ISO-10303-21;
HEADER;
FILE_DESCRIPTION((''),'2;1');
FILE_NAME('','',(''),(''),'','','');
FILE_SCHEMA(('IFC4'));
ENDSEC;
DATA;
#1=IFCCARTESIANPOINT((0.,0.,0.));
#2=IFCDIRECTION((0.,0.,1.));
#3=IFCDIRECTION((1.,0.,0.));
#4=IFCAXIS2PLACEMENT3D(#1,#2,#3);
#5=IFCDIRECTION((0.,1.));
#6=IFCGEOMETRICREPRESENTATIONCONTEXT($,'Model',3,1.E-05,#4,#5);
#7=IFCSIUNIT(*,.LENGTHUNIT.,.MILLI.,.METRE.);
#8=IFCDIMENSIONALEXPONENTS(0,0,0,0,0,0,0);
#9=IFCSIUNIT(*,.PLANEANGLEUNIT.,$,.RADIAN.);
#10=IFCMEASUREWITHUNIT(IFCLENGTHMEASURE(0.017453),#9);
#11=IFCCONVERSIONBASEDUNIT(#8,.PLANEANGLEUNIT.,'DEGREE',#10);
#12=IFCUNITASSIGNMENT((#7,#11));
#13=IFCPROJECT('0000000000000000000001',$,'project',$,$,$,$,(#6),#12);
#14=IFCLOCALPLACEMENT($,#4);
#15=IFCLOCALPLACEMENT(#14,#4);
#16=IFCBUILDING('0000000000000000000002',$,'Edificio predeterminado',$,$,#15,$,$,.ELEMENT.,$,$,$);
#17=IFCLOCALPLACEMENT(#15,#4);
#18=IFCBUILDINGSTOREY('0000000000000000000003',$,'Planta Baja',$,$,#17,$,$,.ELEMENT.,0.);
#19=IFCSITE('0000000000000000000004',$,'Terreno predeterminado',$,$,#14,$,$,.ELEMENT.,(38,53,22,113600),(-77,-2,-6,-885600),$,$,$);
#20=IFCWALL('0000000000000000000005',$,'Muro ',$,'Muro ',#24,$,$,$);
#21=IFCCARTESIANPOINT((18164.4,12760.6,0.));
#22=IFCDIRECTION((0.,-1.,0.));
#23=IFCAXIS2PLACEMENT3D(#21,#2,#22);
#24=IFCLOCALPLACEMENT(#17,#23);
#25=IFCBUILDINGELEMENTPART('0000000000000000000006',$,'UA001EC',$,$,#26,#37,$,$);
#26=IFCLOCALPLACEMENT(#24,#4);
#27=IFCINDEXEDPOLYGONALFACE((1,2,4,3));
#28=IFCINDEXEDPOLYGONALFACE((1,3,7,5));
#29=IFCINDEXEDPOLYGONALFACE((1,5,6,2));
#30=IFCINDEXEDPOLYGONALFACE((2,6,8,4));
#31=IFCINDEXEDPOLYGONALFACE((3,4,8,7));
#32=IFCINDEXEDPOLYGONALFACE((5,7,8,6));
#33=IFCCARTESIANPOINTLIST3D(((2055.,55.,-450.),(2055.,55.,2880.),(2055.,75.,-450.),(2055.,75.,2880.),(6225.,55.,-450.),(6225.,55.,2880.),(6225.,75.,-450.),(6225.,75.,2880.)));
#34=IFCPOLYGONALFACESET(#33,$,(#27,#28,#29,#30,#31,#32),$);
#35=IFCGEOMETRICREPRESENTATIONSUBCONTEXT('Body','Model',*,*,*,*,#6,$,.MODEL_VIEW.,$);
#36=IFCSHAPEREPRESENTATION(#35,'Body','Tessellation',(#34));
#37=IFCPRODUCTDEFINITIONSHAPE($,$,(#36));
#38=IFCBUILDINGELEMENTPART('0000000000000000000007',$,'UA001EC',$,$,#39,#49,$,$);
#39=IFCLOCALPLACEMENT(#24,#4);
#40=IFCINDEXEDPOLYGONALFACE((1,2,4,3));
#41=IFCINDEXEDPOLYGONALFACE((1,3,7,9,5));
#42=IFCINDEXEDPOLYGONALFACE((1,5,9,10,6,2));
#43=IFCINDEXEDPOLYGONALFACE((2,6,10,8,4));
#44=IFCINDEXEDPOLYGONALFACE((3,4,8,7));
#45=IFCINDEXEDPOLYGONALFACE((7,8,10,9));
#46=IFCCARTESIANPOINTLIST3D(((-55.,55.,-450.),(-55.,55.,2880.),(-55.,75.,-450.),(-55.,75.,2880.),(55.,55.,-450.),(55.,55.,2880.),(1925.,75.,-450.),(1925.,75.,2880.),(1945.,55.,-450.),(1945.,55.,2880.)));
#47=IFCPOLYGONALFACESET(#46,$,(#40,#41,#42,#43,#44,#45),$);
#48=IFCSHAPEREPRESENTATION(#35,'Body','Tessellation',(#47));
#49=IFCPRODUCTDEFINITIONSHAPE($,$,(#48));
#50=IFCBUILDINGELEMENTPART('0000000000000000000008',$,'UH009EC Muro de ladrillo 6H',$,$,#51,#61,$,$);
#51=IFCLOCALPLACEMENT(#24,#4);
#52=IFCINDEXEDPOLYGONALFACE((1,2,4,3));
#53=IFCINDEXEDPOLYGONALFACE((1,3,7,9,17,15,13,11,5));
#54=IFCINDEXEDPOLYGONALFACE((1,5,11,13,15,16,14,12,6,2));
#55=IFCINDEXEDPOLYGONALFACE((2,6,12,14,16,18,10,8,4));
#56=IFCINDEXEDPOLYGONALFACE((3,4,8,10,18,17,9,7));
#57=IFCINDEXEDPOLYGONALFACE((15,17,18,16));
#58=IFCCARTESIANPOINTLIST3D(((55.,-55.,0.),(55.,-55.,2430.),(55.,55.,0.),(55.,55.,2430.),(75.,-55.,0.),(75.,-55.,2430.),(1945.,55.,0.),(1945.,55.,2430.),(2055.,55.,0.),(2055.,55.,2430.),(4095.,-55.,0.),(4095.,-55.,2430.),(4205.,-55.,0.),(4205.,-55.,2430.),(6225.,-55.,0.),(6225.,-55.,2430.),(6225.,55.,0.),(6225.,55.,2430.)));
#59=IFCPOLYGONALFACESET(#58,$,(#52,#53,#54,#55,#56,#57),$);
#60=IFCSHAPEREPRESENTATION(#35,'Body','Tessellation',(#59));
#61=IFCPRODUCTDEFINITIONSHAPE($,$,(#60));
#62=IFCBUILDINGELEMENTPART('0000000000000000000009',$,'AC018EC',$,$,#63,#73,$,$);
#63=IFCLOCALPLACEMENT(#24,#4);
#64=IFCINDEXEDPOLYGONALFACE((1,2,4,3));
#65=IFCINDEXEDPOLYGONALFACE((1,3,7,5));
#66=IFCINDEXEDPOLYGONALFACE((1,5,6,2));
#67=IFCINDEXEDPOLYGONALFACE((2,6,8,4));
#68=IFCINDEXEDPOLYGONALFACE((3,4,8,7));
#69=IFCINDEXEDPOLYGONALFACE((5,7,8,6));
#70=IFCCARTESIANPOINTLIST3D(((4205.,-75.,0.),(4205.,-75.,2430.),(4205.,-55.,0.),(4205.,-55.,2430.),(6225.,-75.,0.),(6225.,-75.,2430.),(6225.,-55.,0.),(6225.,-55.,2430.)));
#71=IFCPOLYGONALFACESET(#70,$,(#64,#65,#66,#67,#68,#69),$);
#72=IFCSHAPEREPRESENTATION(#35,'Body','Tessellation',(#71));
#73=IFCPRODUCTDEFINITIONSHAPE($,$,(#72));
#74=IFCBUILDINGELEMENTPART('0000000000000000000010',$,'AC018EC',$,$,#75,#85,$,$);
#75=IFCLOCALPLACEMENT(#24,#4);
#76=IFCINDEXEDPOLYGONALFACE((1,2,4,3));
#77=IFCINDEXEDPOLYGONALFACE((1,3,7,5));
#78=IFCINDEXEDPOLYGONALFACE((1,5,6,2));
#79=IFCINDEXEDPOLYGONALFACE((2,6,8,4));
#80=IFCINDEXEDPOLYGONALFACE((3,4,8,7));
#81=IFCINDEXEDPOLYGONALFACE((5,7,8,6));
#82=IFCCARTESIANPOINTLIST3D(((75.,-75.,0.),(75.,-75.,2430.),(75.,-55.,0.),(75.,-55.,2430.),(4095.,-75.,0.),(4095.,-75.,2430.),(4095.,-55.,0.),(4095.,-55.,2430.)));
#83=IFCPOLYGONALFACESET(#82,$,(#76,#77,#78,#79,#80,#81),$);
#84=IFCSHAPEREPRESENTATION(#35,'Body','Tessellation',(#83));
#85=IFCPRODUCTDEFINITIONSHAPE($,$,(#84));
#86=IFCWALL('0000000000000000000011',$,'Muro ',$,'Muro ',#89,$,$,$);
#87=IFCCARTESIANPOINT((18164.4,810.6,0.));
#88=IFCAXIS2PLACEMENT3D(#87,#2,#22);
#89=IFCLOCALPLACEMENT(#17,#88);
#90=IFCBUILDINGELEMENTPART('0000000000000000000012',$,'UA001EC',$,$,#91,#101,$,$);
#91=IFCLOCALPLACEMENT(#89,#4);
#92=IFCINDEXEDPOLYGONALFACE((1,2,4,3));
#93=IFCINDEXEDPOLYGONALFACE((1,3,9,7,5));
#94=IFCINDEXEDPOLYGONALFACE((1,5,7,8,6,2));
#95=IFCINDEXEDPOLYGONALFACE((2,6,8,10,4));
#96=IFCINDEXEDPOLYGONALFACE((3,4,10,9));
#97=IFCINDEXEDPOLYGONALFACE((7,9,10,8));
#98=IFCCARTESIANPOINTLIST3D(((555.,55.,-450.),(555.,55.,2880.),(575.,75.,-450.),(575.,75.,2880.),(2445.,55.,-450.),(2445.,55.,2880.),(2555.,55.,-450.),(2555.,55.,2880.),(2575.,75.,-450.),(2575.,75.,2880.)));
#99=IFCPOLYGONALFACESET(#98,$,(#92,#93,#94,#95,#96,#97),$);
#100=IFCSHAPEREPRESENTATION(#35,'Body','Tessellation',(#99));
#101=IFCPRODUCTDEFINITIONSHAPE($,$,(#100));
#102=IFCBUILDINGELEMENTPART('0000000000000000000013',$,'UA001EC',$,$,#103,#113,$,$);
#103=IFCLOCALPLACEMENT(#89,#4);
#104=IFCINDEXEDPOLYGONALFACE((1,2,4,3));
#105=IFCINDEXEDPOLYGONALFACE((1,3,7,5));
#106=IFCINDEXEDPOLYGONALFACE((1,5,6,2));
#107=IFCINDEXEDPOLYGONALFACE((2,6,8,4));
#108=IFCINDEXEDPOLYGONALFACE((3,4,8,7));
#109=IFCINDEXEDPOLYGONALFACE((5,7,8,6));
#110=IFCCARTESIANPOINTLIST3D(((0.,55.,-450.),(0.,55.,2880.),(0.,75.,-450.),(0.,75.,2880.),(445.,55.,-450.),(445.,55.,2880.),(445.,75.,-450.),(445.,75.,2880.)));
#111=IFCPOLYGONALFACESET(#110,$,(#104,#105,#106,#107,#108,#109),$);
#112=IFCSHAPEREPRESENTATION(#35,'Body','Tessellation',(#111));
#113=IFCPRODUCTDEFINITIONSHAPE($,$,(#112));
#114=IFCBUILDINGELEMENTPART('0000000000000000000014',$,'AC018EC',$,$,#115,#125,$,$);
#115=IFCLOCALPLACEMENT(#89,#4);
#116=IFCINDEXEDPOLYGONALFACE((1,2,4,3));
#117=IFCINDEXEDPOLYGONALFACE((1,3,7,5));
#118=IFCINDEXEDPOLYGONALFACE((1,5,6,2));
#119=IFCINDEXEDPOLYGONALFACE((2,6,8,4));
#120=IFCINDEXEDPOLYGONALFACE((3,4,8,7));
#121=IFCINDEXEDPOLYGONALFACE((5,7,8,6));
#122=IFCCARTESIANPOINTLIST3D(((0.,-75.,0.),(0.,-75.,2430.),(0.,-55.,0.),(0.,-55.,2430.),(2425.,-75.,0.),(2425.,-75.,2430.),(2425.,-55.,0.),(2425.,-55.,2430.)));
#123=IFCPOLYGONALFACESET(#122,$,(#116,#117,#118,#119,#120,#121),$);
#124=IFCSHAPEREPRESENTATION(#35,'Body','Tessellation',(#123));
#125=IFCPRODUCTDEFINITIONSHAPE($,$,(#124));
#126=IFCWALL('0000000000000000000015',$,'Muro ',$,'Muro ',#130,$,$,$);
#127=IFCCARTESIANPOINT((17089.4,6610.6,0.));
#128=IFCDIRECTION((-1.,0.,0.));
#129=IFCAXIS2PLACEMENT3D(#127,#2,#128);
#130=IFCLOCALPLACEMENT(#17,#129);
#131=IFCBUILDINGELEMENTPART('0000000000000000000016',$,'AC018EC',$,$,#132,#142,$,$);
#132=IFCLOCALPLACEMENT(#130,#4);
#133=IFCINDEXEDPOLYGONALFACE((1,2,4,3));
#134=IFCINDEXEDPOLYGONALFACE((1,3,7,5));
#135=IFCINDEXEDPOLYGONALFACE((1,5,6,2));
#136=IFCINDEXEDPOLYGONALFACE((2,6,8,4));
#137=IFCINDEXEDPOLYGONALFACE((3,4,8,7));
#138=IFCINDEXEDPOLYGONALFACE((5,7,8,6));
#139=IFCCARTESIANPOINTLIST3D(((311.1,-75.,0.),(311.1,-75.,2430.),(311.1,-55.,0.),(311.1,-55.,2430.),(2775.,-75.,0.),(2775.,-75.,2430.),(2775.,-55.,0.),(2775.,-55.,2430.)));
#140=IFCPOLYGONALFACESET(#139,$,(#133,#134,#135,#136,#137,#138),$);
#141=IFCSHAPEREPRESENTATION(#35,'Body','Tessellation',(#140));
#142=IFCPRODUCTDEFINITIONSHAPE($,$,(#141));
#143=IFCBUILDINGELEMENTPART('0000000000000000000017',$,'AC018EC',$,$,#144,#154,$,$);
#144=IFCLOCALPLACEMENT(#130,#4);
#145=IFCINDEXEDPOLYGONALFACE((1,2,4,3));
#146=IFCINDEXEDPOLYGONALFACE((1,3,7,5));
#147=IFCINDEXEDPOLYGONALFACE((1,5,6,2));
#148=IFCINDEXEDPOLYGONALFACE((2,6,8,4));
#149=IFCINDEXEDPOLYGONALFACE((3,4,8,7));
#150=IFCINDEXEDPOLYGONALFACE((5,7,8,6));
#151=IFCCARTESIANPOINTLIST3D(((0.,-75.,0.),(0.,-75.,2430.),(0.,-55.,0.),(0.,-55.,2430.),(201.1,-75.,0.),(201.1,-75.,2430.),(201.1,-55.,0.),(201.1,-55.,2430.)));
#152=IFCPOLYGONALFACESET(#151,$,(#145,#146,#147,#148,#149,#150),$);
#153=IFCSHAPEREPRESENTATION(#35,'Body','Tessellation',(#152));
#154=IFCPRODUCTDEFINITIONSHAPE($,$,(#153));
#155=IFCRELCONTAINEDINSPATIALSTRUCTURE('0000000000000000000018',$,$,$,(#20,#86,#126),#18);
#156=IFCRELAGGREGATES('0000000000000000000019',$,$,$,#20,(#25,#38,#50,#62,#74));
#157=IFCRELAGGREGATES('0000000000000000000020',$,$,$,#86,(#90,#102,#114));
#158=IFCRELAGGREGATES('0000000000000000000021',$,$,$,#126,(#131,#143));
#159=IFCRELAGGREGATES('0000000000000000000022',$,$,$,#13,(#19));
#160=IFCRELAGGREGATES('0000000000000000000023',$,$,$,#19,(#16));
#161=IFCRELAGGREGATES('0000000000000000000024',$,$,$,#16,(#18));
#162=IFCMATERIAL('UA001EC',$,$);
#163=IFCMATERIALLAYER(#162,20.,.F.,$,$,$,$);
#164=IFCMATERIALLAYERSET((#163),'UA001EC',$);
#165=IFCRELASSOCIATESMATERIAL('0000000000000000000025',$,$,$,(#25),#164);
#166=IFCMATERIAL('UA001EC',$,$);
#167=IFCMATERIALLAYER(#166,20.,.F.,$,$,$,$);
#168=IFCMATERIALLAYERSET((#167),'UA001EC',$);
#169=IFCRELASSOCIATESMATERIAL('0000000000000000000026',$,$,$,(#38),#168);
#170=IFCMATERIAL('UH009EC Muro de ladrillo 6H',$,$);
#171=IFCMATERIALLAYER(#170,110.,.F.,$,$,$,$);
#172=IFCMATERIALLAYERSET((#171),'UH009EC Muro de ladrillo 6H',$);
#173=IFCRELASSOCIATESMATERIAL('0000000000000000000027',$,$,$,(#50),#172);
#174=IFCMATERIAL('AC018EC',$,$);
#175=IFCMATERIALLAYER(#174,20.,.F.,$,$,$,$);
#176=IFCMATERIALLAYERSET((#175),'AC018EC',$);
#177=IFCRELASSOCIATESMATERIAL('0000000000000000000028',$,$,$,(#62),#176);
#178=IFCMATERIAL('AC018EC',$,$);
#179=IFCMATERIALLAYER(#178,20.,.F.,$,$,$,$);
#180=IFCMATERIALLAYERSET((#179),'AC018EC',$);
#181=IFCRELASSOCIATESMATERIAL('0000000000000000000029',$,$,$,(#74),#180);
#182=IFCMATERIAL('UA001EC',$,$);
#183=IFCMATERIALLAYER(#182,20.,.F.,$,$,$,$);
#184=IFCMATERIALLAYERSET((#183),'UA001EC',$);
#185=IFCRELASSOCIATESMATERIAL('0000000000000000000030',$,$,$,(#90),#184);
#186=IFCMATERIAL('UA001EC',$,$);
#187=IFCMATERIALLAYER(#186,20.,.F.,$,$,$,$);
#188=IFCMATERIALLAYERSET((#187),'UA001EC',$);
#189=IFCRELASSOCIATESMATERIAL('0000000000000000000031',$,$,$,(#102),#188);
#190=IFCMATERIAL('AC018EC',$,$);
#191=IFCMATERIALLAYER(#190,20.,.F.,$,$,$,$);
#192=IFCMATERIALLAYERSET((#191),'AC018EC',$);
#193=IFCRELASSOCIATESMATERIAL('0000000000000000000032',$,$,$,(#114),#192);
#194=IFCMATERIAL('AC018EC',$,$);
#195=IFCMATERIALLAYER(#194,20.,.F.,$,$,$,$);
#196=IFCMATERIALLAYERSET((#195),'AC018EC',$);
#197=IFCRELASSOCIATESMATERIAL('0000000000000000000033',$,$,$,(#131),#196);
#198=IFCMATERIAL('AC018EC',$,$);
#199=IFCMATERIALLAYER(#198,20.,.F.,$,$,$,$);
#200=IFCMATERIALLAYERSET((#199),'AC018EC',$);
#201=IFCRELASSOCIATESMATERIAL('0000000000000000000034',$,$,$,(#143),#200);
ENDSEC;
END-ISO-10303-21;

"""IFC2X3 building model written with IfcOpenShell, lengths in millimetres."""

from ifc_helpers import new_model, entity, si_unit, converted_unit, direction, frame, origin_with_axes, place, context, subcontext, project, spatial, polyline, outline, extrude, material, layer, layer_set, layer_usage, element, aggregate, save


model = new_model("IFC2X3")

# Units and contexts
model_context = context("Model", 3, precision=1e-05, world=origin_with_axes(), true_north=direction((0.0, 1.0)))
body_context = subcontext(model_context, "Body", "Model", "MODEL_VIEW")
ifc_project = project(units=[si_unit("LENGTHUNIT", "METRE", prefix="MILLI"), converted_unit("PLANEANGLEUNIT", "DEGREE", entity("IfcLengthMeasure", 0.017453), si_unit("PLANEANGLEUNIT", "RADIAN"), dimensions=[0, 0, 0, 0, 0, 0, 0])], contexts=[model_context])

# Site, building, storey
site_placement = place(None, origin_with_axes())
site = spatial("IfcSite", under=ifc_project, at=site_placement, Name="Terreno predeterminado", CompositionType="ELEMENT", RefLatitude=(38, 53, 22, 113600), RefLongitude=(-77, -2, -6, -885600))
building_placement = place(site_placement, origin_with_axes())
building = spatial("IfcBuilding", under=site, at=building_placement, Name="Edificio predeterminado", CompositionType="ELEMENT")
storey_placement = place(building_placement, origin_with_axes())
storey = spatial("IfcBuildingStorey", under=building, at=storey_placement, Name="Planta Baja", CompositionType="ELEMENT", Elevation=0.0)

# Walls, building element parts
wall_1_placement = place(storey_placement, frame((18164.4, 12760.6, 0.0), z_axis=(0.0, 0.0, 1.0), x_axis=(0.0, -1.0, 0.0)))
wall_1 = element("IfcWall", 1, at=wall_1_placement, inside=storey, Name="Muro ", ObjectType="Muro ")
ifc_material_1 = material(Name="UA001EC")
ifc_layer_1 = layer(ifc_material_1, 20.0, ventilated=False)
ifc_layer_set_1 = layer_set([ifc_layer_1], Name="UA001EC")
ifc_layer_usage_1 = layer_usage(ifc_layer_set_1, "AXIS2", "NEGATIVE", -75.0)
building_element_part_1_placement = place(wall_1_placement, origin_with_axes())
building_element_part_1 = element("IfcBuildingElementPart", 2, at=building_element_part_1_placement, material=ifc_layer_usage_1, Name="UA001EC", context=body_context, shape_type="SweptSolid", body=[
    extrude(outline(polyline([(6225.0, 75.0), (6225.0, 55.0), (2055.0, 55.0), (2055.0, 75.0), (6225.0, 75.0)])), frame((0.0, 0.0, -450.0), z_axis=(0.0, 0.0, 1.0), x_axis=(1.0, 0.0, 0.0)), (0.0, 0.0, 1.0), 3330.0),
])
ifc_material_2 = material(Name="UA001EC")
ifc_layer_2 = layer(ifc_material_2, 20.0, ventilated=False)
ifc_layer_set_2 = layer_set([ifc_layer_2], Name="UA001EC")
ifc_layer_usage_2 = layer_usage(ifc_layer_set_2, "AXIS2", "NEGATIVE", -75.0)
building_element_part_2_placement = place(wall_1_placement, origin_with_axes())
building_element_part_2 = element("IfcBuildingElementPart", 3, at=building_element_part_2_placement, material=ifc_layer_usage_2, Name="UA001EC", context=body_context, shape_type="SweptSolid", body=[
    extrude(outline(polyline([(1925.0, 75.0), (1945.0, 55.0), (55.0, 55.0), (-55.0, 55.0), (-55.0, 75.0), (1925.0, 75.0)])), frame((0.0, 0.0, -450.0), z_axis=(0.0, 0.0, 1.0), x_axis=(1.0, 0.0, 0.0)), (0.0, 0.0, 1.0), 3330.0),
])
ifc_material_3 = material(Name="UH009EC Muro de ladrillo 6H")
ifc_layer_3 = layer(ifc_material_3, 110.0, ventilated=False)
ifc_layer_set_3 = layer_set([ifc_layer_3], Name="UH009EC Muro de ladrillo 6H")
ifc_layer_usage_3 = layer_usage(ifc_layer_set_3, "AXIS2", "NEGATIVE", -55.0)
building_element_part_3_placement = place(wall_1_placement, origin_with_axes())
building_element_part_3 = element("IfcBuildingElementPart", 4, at=building_element_part_3_placement, material=ifc_layer_usage_3, Name="UH009EC Muro de ladrillo 6H", context=body_context, shape_type="SweptSolid", body=[
    extrude(outline(polyline([(6225.0, 55.0), (6225.0, -55.0), (4205.0, -55.0), (4095.0, -55.0), (75.0, -55.0), (55.0, -55.0), (55.0, 55.0), (1945.0, 55.0), (2055.0, 55.0), (6225.0, 55.0)])), origin_with_axes(), (0.0, 0.0, 1.0), 2430.0),
])
ifc_material_4 = material(Name="AC018EC")
ifc_layer_4 = layer(ifc_material_4, 20.0, ventilated=False)
ifc_layer_set_4 = layer_set([ifc_layer_4], Name="AC018EC")
ifc_layer_usage_4 = layer_usage(ifc_layer_set_4, "AXIS2", "NEGATIVE", 55.0)
building_element_part_4_placement = place(wall_1_placement, origin_with_axes())
building_element_part_4 = element("IfcBuildingElementPart", 5, at=building_element_part_4_placement, material=ifc_layer_usage_4, Name="AC018EC", context=body_context, shape_type="SweptSolid", body=[
    extrude(outline(polyline([(6225.0, -55.0), (6225.0, -75.0), (4205.0, -75.0), (4205.0, -55.0), (6225.0, -55.0)])), origin_with_axes(), (0.0, 0.0, 1.0), 2430.0),
])
ifc_material_5 = material(Name="AC018EC")
ifc_layer_5 = layer(ifc_material_5, 20.0, ventilated=False)
ifc_layer_set_5 = layer_set([ifc_layer_5], Name="AC018EC")
ifc_layer_usage_5 = layer_usage(ifc_layer_set_5, "AXIS2", "NEGATIVE", 55.0)
building_element_part_5_placement = place(wall_1_placement, origin_with_axes())
building_element_part_5 = element("IfcBuildingElementPart", 6, at=building_element_part_5_placement, material=ifc_layer_usage_5, Name="AC018EC", context=body_context, shape_type="SweptSolid", body=[
    extrude(outline(polyline([(4095.0, -55.0), (4095.0, -75.0), (75.0, -75.0), (75.0, -55.0), (4095.0, -55.0)])), origin_with_axes(), (0.0, 0.0, 1.0), 2430.0),
])
aggregate(wall_1, [building_element_part_1, building_element_part_2, building_element_part_3, building_element_part_4, building_element_part_5])
wall_2_placement = place(storey_placement, frame((18164.4, 810.6, 0.0), z_axis=(0.0, 0.0, 1.0), x_axis=(0.0, -1.0, 0.0)))
wall_2 = element("IfcWall", 7, at=wall_2_placement, inside=storey, Name="Muro ", ObjectType="Muro ")
ifc_material_6 = material(Name="UA001EC")
ifc_layer_6 = layer(ifc_material_6, 20.0, ventilated=False)
ifc_layer_set_6 = layer_set([ifc_layer_6], Name="UA001EC")
ifc_layer_usage_6 = layer_usage(ifc_layer_set_6, "AXIS2", "NEGATIVE", -75.0)
building_element_part_6_placement = place(wall_2_placement, origin_with_axes())
building_element_part_6 = element("IfcBuildingElementPart", 8, at=building_element_part_6_placement, material=ifc_layer_usage_6, Name="UA001EC", context=body_context, shape_type="SweptSolid", body=[
    extrude(outline(polyline([(2575.0, 75.0), (2555.0, 55.0), (2445.0, 55.0), (555.0, 55.0), (575.0, 75.0), (2575.0, 75.0)])), frame((0.0, 0.0, -450.0), z_axis=(0.0, 0.0, 1.0), x_axis=(1.0, 0.0, 0.0)), (0.0, 0.0, 1.0), 3330.0),
])
ifc_material_7 = material(Name="UA001EC")
ifc_layer_7 = layer(ifc_material_7, 20.0, ventilated=False)
ifc_layer_set_7 = layer_set([ifc_layer_7], Name="UA001EC")
ifc_layer_usage_7 = layer_usage(ifc_layer_set_7, "AXIS2", "NEGATIVE", -75.0)
building_element_part_7_placement = place(wall_2_placement, origin_with_axes())
building_element_part_7 = element("IfcBuildingElementPart", 9, at=building_element_part_7_placement, material=ifc_layer_usage_7, Name="UA001EC", context=body_context, shape_type="SweptSolid", body=[
    extrude(outline(polyline([(445.0, 75.0), (445.0, 55.0), (0.0, 55.0), (0.0, 75.0), (445.0, 75.0)])), frame((0.0, 0.0, -450.0), z_axis=(0.0, 0.0, 1.0), x_axis=(1.0, 0.0, 0.0)), (0.0, 0.0, 1.0), 3330.0),
])
ifc_material_8 = material(Name="AC018EC")
ifc_layer_8 = layer(ifc_material_8, 20.0, ventilated=False)
ifc_layer_set_8 = layer_set([ifc_layer_8], Name="AC018EC")
ifc_layer_usage_8 = layer_usage(ifc_layer_set_8, "AXIS2", "NEGATIVE", 55.0)
building_element_part_8_placement = place(wall_2_placement, origin_with_axes())
building_element_part_8 = element("IfcBuildingElementPart", 10, at=building_element_part_8_placement, material=ifc_layer_usage_8, Name="AC018EC", context=body_context, shape_type="SweptSolid", body=[
    extrude(outline(polyline([(2425.0, -55.0), (2425.0, -75.0), (0.0, -75.0), (0.0, -55.0), (2425.0, -55.0)])), origin_with_axes(), (0.0, 0.0, 1.0), 2430.0),
])
aggregate(wall_2, [building_element_part_6, building_element_part_7, building_element_part_8])
wall_3_placement = place(storey_placement, frame((17089.4, 6610.6, 0.0), z_axis=(0.0, 0.0, 1.0), x_axis=(-1.0, 0.0, 0.0)))
wall_3 = element("IfcWall", 11, at=wall_3_placement, inside=storey, Name="Muro ", ObjectType="Muro ")
ifc_material_9 = material(Name="AC018EC")
ifc_layer_9 = layer(ifc_material_9, 20.0, ventilated=False)
ifc_layer_set_9 = layer_set([ifc_layer_9], Name="AC018EC")
ifc_layer_usage_9 = layer_usage(ifc_layer_set_9, "AXIS2", "NEGATIVE", 55.0)
building_element_part_9_placement = place(wall_3_placement, origin_with_axes())
building_element_part_9 = element("IfcBuildingElementPart", 12, at=building_element_part_9_placement, material=ifc_layer_usage_9, Name="AC018EC", context=body_context, shape_type="SweptSolid", body=[
    extrude(outline(polyline([(2775.0, -55.0), (2775.0, -75.0), (311.1, -75.0), (311.1, -55.0), (2775.0, -55.0)])), origin_with_axes(), (0.0, 0.0, 1.0), 2430.0),
])
ifc_material_10 = material(Name="AC018EC")
ifc_layer_10 = layer(ifc_material_10, 20.0, ventilated=False)
ifc_layer_set_10 = layer_set([ifc_layer_10], Name="AC018EC")
ifc_layer_usage_10 = layer_usage(ifc_layer_set_10, "AXIS2", "NEGATIVE", 55.0)
building_element_part_10_placement = place(wall_3_placement, origin_with_axes())
building_element_part_10 = element("IfcBuildingElementPart", 13, at=building_element_part_10_placement, material=ifc_layer_usage_10, Name="AC018EC", context=body_context, shape_type="SweptSolid", body=[
    extrude(outline(polyline([(201.1, -55.0), (201.1, -75.0), (0.0, -75.0), (0.0, -55.0), (201.1, -55.0)])), origin_with_axes(), (0.0, 0.0, 1.0), 2430.0),
])
aggregate(wall_3, [building_element_part_9, building_element_part_10])

save(model, "model.ifc")
